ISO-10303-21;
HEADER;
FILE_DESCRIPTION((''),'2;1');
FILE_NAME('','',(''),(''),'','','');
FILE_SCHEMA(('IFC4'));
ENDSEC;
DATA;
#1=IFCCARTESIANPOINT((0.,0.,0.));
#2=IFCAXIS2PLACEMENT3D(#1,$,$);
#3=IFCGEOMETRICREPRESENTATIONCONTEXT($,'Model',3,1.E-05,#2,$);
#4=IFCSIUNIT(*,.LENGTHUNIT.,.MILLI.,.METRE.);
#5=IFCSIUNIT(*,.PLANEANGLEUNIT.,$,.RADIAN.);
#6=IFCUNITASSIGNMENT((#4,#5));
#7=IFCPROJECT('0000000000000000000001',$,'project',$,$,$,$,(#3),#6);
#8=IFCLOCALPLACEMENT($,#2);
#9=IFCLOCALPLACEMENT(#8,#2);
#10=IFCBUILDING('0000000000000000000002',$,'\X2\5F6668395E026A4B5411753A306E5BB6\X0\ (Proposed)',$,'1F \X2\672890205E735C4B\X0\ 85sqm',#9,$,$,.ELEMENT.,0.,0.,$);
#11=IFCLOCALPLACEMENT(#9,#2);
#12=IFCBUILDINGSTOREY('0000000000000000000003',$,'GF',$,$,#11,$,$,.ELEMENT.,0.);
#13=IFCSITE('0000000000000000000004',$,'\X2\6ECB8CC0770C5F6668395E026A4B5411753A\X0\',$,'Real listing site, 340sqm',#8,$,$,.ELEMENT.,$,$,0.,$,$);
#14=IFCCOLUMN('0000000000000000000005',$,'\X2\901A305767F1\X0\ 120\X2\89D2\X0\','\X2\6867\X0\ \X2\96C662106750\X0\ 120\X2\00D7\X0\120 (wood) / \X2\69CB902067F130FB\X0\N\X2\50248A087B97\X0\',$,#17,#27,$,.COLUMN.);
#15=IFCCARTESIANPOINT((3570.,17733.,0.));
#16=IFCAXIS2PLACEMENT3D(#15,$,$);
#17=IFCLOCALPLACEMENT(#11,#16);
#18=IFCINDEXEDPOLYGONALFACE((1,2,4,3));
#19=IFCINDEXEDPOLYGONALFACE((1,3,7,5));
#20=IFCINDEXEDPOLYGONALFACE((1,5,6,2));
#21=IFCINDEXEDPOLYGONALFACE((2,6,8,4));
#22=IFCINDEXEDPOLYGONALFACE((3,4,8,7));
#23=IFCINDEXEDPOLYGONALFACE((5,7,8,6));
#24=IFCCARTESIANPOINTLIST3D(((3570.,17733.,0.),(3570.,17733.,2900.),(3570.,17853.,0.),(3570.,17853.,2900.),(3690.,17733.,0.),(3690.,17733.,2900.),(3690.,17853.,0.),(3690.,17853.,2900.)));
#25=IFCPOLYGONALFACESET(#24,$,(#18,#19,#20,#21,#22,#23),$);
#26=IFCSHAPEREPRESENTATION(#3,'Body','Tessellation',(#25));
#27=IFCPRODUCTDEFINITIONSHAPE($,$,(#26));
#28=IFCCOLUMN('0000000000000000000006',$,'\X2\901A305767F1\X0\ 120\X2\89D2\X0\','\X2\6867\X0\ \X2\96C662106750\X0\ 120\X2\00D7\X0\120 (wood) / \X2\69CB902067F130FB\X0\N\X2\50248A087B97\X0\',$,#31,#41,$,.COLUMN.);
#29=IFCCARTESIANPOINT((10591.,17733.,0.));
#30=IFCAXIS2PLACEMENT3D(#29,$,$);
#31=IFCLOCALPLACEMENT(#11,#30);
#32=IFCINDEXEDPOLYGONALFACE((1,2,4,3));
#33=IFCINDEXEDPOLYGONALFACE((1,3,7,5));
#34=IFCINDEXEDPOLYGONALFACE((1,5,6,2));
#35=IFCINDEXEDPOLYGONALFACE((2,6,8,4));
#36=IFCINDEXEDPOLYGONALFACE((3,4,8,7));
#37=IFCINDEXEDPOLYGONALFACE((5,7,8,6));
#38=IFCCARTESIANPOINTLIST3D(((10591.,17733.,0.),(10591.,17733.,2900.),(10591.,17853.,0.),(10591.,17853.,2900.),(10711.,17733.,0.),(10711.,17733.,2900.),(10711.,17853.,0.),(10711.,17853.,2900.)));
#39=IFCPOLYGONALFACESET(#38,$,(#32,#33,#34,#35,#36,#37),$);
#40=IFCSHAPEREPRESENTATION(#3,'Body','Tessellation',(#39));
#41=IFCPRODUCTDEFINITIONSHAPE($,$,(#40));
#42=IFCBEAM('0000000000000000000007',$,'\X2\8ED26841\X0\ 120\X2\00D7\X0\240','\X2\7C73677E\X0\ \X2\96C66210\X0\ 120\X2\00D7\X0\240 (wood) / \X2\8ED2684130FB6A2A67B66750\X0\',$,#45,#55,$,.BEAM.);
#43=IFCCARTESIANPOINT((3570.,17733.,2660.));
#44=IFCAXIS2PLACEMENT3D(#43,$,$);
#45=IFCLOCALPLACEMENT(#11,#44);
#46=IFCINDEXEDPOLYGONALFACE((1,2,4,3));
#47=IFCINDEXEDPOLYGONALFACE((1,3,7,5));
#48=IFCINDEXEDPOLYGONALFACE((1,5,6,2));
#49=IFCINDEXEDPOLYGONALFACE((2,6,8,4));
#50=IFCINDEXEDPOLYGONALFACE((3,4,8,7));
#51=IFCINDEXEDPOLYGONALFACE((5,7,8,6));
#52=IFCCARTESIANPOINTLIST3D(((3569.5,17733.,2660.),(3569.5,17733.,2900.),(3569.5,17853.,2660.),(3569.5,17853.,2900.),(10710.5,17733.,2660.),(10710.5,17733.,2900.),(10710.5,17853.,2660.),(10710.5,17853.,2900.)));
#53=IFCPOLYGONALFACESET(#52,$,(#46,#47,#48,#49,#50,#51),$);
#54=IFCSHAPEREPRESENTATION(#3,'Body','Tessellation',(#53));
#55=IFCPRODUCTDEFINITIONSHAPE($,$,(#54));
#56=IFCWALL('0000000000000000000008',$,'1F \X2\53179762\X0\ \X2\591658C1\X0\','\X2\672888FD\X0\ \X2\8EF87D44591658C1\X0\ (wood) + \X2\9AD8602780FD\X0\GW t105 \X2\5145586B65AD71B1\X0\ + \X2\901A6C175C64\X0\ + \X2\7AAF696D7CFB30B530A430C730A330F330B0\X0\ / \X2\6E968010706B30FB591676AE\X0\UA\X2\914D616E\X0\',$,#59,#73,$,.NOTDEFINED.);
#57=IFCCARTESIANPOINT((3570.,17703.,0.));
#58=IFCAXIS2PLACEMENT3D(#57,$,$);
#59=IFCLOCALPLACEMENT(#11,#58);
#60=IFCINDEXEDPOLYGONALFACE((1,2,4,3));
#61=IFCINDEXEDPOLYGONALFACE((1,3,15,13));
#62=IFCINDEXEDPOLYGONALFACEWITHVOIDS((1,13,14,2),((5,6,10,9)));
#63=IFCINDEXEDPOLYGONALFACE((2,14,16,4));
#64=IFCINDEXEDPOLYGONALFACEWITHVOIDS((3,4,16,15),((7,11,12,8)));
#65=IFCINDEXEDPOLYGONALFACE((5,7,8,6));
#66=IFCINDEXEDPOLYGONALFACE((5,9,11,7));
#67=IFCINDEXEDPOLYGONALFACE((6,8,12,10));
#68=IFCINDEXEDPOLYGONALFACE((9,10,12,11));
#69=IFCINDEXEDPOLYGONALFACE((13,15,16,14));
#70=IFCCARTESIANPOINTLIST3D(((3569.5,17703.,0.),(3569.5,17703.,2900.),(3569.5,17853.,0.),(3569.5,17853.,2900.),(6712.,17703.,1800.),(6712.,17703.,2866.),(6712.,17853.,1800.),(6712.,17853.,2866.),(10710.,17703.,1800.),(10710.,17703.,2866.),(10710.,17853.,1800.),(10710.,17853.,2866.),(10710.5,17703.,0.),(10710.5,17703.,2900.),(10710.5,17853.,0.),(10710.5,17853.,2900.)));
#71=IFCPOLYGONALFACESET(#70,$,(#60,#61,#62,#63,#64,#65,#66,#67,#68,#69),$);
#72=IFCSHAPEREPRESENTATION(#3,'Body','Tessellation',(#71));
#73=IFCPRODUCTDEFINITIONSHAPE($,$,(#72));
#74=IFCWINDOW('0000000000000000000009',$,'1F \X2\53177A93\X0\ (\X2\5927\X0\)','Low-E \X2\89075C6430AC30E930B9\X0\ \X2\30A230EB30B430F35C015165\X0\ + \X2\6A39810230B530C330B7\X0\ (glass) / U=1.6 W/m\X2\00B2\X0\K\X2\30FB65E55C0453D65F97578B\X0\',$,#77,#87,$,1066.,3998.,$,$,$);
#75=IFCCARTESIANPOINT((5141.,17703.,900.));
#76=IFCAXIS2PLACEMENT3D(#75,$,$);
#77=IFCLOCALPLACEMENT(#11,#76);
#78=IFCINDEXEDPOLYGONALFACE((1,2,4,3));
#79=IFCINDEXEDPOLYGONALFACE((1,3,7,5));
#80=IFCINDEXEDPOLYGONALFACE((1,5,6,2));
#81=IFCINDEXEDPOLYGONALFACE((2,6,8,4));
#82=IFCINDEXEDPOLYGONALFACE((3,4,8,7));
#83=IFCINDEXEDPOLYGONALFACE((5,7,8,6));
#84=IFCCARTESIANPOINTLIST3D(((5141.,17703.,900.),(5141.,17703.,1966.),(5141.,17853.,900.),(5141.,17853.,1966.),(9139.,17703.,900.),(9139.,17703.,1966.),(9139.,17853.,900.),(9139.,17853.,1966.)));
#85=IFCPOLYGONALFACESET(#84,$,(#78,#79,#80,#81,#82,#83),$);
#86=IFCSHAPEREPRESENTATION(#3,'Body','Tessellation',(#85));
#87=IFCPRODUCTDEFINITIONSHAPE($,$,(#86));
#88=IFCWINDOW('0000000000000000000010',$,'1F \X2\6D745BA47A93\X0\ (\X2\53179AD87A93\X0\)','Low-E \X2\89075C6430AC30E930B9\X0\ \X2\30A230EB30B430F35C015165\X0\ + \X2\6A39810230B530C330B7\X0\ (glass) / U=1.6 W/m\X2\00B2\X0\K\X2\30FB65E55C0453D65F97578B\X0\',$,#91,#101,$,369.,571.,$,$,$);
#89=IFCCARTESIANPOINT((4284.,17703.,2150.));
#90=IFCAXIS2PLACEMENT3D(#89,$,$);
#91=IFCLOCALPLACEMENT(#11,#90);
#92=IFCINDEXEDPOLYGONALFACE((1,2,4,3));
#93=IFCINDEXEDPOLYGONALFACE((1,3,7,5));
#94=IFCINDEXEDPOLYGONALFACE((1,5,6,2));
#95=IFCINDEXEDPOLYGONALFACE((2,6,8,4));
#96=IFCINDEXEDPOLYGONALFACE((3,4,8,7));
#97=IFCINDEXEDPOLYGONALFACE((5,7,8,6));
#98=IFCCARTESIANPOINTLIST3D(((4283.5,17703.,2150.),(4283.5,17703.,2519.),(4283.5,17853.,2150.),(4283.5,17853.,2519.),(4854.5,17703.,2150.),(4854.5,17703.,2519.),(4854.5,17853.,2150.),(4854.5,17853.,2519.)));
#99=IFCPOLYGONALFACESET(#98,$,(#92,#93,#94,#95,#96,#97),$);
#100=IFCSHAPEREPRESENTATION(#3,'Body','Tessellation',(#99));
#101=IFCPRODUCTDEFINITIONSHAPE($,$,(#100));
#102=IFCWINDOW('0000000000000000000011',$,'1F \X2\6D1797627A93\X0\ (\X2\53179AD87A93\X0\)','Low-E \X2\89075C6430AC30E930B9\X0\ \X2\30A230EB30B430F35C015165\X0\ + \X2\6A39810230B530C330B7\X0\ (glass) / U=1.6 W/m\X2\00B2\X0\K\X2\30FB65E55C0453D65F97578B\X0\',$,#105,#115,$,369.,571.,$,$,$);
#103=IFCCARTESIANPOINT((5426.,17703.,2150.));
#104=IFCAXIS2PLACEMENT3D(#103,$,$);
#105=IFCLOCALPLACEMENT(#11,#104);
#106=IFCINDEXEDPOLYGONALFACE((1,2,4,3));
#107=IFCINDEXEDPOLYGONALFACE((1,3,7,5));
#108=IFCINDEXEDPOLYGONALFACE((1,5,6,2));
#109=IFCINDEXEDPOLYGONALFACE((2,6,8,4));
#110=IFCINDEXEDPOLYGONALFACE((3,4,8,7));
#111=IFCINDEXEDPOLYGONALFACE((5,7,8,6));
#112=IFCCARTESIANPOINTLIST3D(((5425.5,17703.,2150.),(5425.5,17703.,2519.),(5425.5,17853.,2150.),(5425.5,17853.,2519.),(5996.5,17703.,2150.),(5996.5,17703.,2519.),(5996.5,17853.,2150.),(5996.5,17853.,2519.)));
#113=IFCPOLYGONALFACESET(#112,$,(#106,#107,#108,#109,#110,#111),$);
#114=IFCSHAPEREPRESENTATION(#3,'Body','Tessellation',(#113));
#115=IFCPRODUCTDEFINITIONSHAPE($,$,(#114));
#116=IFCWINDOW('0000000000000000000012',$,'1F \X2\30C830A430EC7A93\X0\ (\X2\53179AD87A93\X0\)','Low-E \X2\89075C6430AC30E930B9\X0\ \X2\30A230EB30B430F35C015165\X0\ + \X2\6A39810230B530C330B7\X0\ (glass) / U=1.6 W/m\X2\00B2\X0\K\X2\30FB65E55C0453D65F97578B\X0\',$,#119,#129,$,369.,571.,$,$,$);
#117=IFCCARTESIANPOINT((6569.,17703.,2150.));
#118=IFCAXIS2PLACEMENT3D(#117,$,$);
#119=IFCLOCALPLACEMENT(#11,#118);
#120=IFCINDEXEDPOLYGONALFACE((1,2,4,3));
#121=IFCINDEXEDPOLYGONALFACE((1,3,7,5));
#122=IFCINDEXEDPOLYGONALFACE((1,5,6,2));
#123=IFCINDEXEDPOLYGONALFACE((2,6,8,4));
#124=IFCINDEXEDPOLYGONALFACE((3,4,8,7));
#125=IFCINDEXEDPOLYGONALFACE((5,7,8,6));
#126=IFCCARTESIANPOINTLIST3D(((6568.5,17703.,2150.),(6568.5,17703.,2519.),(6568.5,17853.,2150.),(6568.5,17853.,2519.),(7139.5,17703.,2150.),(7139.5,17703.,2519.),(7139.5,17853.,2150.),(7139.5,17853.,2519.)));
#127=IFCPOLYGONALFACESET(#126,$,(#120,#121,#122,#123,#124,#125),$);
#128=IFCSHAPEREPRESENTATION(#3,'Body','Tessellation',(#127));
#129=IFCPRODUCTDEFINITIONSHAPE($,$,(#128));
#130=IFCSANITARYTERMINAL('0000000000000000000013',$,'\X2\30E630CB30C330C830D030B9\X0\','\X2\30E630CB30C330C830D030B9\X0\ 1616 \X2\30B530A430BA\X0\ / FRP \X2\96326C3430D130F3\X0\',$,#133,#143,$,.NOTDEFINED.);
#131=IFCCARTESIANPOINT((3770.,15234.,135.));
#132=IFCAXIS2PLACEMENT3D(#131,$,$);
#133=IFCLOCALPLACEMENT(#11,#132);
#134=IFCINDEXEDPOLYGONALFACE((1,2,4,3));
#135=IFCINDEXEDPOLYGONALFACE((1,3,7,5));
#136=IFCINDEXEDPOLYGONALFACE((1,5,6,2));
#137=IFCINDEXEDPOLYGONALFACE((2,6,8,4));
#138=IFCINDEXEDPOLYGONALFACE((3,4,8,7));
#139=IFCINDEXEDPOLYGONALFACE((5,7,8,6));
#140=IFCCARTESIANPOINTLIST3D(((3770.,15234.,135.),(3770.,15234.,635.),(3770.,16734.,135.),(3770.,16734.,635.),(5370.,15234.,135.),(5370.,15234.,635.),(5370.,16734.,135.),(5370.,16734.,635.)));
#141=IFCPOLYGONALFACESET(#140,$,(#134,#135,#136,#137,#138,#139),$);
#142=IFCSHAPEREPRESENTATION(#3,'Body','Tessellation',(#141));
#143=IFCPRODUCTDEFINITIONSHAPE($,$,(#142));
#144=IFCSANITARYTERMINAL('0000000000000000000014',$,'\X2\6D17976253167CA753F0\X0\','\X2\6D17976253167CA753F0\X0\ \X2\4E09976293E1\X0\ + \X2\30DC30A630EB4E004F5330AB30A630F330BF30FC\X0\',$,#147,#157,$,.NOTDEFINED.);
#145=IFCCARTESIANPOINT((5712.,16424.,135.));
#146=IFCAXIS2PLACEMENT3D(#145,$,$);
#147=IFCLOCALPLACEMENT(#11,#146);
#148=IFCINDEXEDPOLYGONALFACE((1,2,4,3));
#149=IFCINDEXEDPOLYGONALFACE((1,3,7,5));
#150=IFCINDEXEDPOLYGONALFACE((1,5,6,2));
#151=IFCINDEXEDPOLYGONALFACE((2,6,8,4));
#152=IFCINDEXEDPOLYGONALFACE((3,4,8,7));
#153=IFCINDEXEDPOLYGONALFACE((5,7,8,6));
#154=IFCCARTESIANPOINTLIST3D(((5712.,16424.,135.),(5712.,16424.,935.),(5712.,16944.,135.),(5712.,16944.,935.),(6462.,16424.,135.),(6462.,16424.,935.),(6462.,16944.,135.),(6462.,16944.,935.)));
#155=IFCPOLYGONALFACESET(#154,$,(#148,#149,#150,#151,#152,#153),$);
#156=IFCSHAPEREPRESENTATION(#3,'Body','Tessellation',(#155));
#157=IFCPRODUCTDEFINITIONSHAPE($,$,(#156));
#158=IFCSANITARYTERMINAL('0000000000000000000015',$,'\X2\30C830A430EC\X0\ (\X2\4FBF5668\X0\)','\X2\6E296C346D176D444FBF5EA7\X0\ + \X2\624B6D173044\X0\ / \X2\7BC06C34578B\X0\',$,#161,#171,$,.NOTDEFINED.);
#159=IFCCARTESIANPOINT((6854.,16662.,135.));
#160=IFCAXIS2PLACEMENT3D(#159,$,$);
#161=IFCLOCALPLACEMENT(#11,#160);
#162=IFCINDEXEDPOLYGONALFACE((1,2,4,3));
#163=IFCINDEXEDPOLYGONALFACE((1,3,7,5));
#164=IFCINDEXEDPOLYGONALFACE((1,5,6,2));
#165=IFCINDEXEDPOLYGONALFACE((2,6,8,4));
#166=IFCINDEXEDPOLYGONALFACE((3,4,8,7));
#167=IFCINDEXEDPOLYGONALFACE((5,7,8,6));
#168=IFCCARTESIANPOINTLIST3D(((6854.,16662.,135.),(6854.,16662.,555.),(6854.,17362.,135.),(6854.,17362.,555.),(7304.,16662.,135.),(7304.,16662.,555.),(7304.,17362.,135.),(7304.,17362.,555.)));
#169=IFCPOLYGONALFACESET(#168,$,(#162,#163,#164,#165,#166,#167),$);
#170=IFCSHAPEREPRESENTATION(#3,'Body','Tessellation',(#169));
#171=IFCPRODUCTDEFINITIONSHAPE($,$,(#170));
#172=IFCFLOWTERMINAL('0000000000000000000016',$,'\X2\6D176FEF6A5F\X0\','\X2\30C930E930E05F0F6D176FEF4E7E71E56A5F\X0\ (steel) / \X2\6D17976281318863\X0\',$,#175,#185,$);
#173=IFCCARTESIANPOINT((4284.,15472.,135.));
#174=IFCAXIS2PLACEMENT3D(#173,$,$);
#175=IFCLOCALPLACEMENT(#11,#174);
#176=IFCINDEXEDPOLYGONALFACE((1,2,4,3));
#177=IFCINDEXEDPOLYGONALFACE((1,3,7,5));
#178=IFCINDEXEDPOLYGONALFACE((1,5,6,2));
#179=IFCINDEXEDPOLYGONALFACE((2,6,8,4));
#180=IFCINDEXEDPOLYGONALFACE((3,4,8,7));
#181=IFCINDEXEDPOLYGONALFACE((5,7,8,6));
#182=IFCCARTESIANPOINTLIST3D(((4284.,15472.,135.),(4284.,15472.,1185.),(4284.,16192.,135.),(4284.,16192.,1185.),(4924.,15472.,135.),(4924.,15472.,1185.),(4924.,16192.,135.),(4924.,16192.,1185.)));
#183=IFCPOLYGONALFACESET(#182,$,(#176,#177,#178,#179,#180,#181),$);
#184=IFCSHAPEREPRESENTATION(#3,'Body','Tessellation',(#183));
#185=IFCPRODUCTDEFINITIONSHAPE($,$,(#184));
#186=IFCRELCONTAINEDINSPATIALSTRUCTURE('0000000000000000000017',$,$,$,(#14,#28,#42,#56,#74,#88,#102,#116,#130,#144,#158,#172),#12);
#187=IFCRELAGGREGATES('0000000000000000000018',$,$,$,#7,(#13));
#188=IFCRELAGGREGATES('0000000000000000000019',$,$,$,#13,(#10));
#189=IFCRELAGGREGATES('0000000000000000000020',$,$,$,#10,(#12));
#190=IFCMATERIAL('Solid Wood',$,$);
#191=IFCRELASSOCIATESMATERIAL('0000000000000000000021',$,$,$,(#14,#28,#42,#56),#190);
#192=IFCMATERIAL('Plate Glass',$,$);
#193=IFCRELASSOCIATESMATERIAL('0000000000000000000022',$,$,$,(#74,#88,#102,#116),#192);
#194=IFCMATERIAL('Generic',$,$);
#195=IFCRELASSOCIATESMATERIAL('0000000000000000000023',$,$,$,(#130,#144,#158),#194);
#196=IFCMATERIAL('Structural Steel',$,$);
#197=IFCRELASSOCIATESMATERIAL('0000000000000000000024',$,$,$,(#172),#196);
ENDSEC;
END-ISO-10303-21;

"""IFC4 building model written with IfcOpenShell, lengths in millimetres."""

from ifc_helpers import new_model, si_unit, frame, frame_2d, origin, place, context, project, spatial, rectangle, extrude, material, element, fill, save


model = new_model("IFC4")

# Units and contexts
model_context = context("Model", 3, precision=1e-05, world=origin())
ifc_project = project(units=[si_unit("LENGTHUNIT", "METRE", prefix="MILLI"), si_unit("PLANEANGLEUNIT", "RADIAN")], contexts=[model_context])

# Site, building, storey
site_placement = place(None, origin())
site = spatial("IfcSite", under=ifc_project, at=site_placement, Name="滋賀県彦根市橋向町", ObjectType="Real listing site, 340sqm", CompositionType="ELEMENT", RefElevation=0.0)
building_placement = place(site_placement, origin())
building = spatial("IfcBuilding", under=site, at=building_placement, Name="彦根市橋向町の家 (Proposed)", ObjectType="1F 木造平屋 85sqm", CompositionType="ELEMENT", ElevationOfRefHeight=0.0, ElevationOfTerrain=0.0)
storey_placement = place(building_placement, origin())
storey = spatial("IfcBuildingStorey", under=building, at=storey_placement, Name="GF", CompositionType="ELEMENT", Elevation=0.0)

# Columns
ifc_material_1 = material(Name="Solid Wood")
column_1_placement = place(storey_placement, frame((3570.0, 17733.0, 0.0)))
element("IfcColumn", 1, at=column_1_placement, inside=storey, material=ifc_material_1, Name="通し柱 120角", Description="桧 集成材 120×120 (wood) / 構造柱・N値計算", PredefinedType="COLUMN", context=model_context, shape_type="SweptSolid", body=[
    extrude(rectangle(XDim=120.0, YDim=120.0, at=frame_2d((60.0, 60.0))), frame((3570.0, 17733.0, 0.0)), (0.0, 0.0, 1.0), 2900.0),
])
column_2_placement = place(storey_placement, frame((10591.0, 17733.0, 0.0)))
element("IfcColumn", 2, at=column_2_placement, inside=storey, material=ifc_material_1, Name="通し柱 120角", Description="桧 集成材 120×120 (wood) / 構造柱・N値計算", PredefinedType="COLUMN", context=model_context, shape_type="SweptSolid", body=[
    extrude(rectangle(XDim=120.0, YDim=120.0, at=frame_2d((60.0, 60.0))), frame((10591.0, 17733.0, 0.0)), (0.0, 0.0, 1.0), 2900.0),
])

# Beam
beam_1_placement = place(storey_placement, frame((3570.0, 17733.0, 2660.0)))
element("IfcBeam", 3, at=beam_1_placement, inside=storey, material=ifc_material_1, Name="軒桁 120×240", Description="米松 集成 120×240 (wood) / 軒桁・横架材", PredefinedType="BEAM", context=model_context, shape_type="SweptSolid", body=[
    extrude(rectangle(XDim=7141.0, YDim=120.0, at=frame_2d((3570.0, 60.0))), frame((3570.0, 17733.0, 2660.0)), (0.0, 0.0, 1.0), 240.0),
])

# Wall, openings, windows
wall_placement = place(storey_placement, frame((3570.0, 17703.0, 0.0)))
wall = element("IfcWall", 4, at=wall_placement, inside=storey, material=ifc_material_1, Name="1F 北面 外壁", Description="木製 軸組外壁 (wood) + 高性能GW t105 充填断熱 + 通気層 + 窯業系サイディング / 準耐火・外皮UA配慮", PredefinedType="NOTDEFINED", context=model_context, shape_type="SweptSolid", body=[
    extrude(rectangle(XDim=7141.0, YDim=150.0, at=frame_2d((3570.0, 75.0))), frame((3570.0, 17703.0, 0.0)), (0.0, 0.0, 1.0), 2900.0),
])
opening_1_placement = place(storey_placement, frame((5141.0, 17703.0, 900.0)))
opening_1 = element("IfcOpeningElement", 5, at=opening_1_placement, cuts=wall, PredefinedType="NOTDEFINED", context=model_context, shape_type="SweptSolid", body=[
    extrude(rectangle(XDim=3998.0, YDim=150.0, at=frame_2d((1999.0, 75.0))), frame((5141.0, 17703.0, 900.0)), (0.0, 0.0, 1.0), 1066.0),
])
opening_2_placement = place(storey_placement, frame((4284.0, 17703.0, 2150.0)))
opening_2 = element("IfcOpeningElement", 6, at=opening_2_placement, cuts=wall, PredefinedType="NOTDEFINED", context=model_context, shape_type="SweptSolid", body=[
    extrude(rectangle(XDim=571.0, YDim=150.0, at=frame_2d((285.0, 75.0))), frame((4284.0, 17703.0, 2150.0)), (0.0, 0.0, 1.0), 369.0),
])
opening_3_placement = place(storey_placement, frame((5426.0, 17703.0, 2150.0)))
opening_3 = element("IfcOpeningElement", 7, at=opening_3_placement, cuts=wall, PredefinedType="NOTDEFINED", context=model_context, shape_type="SweptSolid", body=[
    extrude(rectangle(XDim=571.0, YDim=150.0, at=frame_2d((285.0, 75.0))), frame((5426.0, 17703.0, 2150.0)), (0.0, 0.0, 1.0), 369.0),
])
opening_4_placement = place(storey_placement, frame((6569.0, 17703.0, 2150.0)))
opening_4 = element("IfcOpeningElement", 8, at=opening_4_placement, cuts=wall, PredefinedType="NOTDEFINED", context=model_context, shape_type="SweptSolid", body=[
    extrude(rectangle(XDim=571.0, YDim=150.0, at=frame_2d((285.0, 75.0))), frame((6569.0, 17703.0, 2150.0)), (0.0, 0.0, 1.0), 369.0),
])
ifc_material_2 = material(Name="Plate Glass")
window_1_placement = place(storey_placement, frame((5141.0, 17703.0, 900.0)))
window_1 = element("IfcWindow", 9, at=window_1_placement, inside=storey, material=ifc_material_2, Name="1F 北窓 (大)", Description="Low-E 複層ガラス アルゴン封入 + 樹脂サッシ (glass) / U=1.6 W/m²K・日射取得型", OverallHeight=1066.0, OverallWidth=3998.0, context=model_context, shape_type="SweptSolid", body=[
    extrude(rectangle(XDim=3998.0, YDim=150.0, at=frame_2d((1999.0, 75.0))), frame((5141.0, 17703.0, 900.0)), (0.0, 0.0, 1.0), 1066.0),
])
fill(opening_1, window_1)
window_2_placement = place(storey_placement, frame((4284.0, 17703.0, 2150.0)))
window_2 = element("IfcWindow", 10, at=window_2_placement, inside=storey, material=ifc_material_2, Name="1F 浴室窓 (北高窓)", Description="Low-E 複層ガラス アルゴン封入 + 樹脂サッシ (glass) / U=1.6 W/m²K・日射取得型", OverallHeight=369.0, OverallWidth=571.0, context=model_context, shape_type="SweptSolid", body=[
    extrude(rectangle(XDim=571.0, YDim=150.0, at=frame_2d((285.0, 75.0))), frame((4284.0, 17703.0, 2150.0)), (0.0, 0.0, 1.0), 369.0),
])
fill(opening_2, window_2)
window_3_placement = place(storey_placement, frame((5426.0, 17703.0, 2150.0)))
window_3 = element("IfcWindow", 11, at=window_3_placement, inside=storey, material=ifc_material_2, Name="1F 洗面窓 (北高窓)", Description="Low-E 複層ガラス アルゴン封入 + 樹脂サッシ (glass) / U=1.6 W/m²K・日射取得型", OverallHeight=369.0, OverallWidth=571.0, context=model_context, shape_type="SweptSolid", body=[
    extrude(rectangle(XDim=571.0, YDim=150.0, at=frame_2d((285.0, 75.0))), frame((5426.0, 17703.0, 2150.0)), (0.0, 0.0, 1.0), 369.0),
])
fill(opening_3, window_3)
window_4_placement = place(storey_placement, frame((6569.0, 17703.0, 2150.0)))
window_4 = element("IfcWindow", 12, at=window_4_placement, inside=storey, material=ifc_material_2, Name="1F トイレ窓 (北高窓)", Description="Low-E 複層ガラス アルゴン封入 + 樹脂サッシ (glass) / U=1.6 W/m²K・日射取得型", OverallHeight=369.0, OverallWidth=571.0, context=model_context, shape_type="SweptSolid", body=[
    extrude(rectangle(XDim=571.0, YDim=150.0, at=frame_2d((285.0, 75.0))), frame((6569.0, 17703.0, 2150.0)), (0.0, 0.0, 1.0), 369.0),
])
fill(opening_4, window_4)

# Sanitary terminals
ifc_material_3 = material(Name="Generic")
sanitary_terminal_1_placement = place(storey_placement, frame((3770.0, 15234.0, 135.0)))
element("IfcSanitaryTerminal", 13, at=sanitary_terminal_1_placement, inside=storey, material=ifc_material_3, Name="ユニットバス", Description="ユニットバス 1616 サイズ / FRP 防水パン", PredefinedType="NOTDEFINED", context=model_context, shape_type="SweptSolid", body=[
    extrude(rectangle(XDim=1600.0, YDim=1500.0, at=frame_2d((800.0, 750.0))), frame((3770.0, 15234.0, 135.0)), (0.0, 0.0, 1.0), 500.0),
])
sanitary_terminal_2_placement = place(storey_placement, frame((5712.0, 16424.0, 135.0)))
element("IfcSanitaryTerminal", 14, at=sanitary_terminal_2_placement, inside=storey, material=ifc_material_3, Name="洗面化粧台", Description="洗面化粧台 三面鏡 + ボウル一体カウンター", PredefinedType="NOTDEFINED", context=model_context, shape_type="SweptSolid", body=[
    extrude(rectangle(XDim=750.0, YDim=520.0, at=frame_2d((375.0, 260.0))), frame((5712.0, 16424.0, 135.0)), (0.0, 0.0, 1.0), 800.0),
])
sanitary_terminal_3_placement = place(storey_placement, frame((6854.0, 16662.0, 135.0)))
element("IfcSanitaryTerminal", 15, at=sanitary_terminal_3_placement, inside=storey, material=ifc_material_3, Name="トイレ (便器)", Description="温水洗浄便座 + 手洗い / 節水型", PredefinedType="NOTDEFINED", context=model_context, shape_type="SweptSolid", body=[
    extrude(rectangle(XDim=450.0, YDim=700.0, at=frame_2d((225.0, 350.0))), frame((6854.0, 16662.0, 135.0)), (0.0, 0.0, 1.0), 420.0),
])

# Flow terminal
ifc_material_4 = material(Name="Structural Steel")
flow_terminal_placement = place(storey_placement, frame((4284.0, 15472.0, 135.0)))
element("IfcFlowTerminal", 16, at=flow_terminal_placement, inside=storey, material=ifc_material_4, Name="洗濯機", Description="ドラム式洗濯乾燥機 (steel) / 洗面脱衣", context=model_context, shape_type="SweptSolid", body=[
    extrude(rectangle(XDim=640.0, YDim=720.0, at=frame_2d((320.0, 360.0))), frame((4284.0, 15472.0, 135.0)), (0.0, 0.0, 1.0), 1050.0),
])

save(model, "model.ifc")
